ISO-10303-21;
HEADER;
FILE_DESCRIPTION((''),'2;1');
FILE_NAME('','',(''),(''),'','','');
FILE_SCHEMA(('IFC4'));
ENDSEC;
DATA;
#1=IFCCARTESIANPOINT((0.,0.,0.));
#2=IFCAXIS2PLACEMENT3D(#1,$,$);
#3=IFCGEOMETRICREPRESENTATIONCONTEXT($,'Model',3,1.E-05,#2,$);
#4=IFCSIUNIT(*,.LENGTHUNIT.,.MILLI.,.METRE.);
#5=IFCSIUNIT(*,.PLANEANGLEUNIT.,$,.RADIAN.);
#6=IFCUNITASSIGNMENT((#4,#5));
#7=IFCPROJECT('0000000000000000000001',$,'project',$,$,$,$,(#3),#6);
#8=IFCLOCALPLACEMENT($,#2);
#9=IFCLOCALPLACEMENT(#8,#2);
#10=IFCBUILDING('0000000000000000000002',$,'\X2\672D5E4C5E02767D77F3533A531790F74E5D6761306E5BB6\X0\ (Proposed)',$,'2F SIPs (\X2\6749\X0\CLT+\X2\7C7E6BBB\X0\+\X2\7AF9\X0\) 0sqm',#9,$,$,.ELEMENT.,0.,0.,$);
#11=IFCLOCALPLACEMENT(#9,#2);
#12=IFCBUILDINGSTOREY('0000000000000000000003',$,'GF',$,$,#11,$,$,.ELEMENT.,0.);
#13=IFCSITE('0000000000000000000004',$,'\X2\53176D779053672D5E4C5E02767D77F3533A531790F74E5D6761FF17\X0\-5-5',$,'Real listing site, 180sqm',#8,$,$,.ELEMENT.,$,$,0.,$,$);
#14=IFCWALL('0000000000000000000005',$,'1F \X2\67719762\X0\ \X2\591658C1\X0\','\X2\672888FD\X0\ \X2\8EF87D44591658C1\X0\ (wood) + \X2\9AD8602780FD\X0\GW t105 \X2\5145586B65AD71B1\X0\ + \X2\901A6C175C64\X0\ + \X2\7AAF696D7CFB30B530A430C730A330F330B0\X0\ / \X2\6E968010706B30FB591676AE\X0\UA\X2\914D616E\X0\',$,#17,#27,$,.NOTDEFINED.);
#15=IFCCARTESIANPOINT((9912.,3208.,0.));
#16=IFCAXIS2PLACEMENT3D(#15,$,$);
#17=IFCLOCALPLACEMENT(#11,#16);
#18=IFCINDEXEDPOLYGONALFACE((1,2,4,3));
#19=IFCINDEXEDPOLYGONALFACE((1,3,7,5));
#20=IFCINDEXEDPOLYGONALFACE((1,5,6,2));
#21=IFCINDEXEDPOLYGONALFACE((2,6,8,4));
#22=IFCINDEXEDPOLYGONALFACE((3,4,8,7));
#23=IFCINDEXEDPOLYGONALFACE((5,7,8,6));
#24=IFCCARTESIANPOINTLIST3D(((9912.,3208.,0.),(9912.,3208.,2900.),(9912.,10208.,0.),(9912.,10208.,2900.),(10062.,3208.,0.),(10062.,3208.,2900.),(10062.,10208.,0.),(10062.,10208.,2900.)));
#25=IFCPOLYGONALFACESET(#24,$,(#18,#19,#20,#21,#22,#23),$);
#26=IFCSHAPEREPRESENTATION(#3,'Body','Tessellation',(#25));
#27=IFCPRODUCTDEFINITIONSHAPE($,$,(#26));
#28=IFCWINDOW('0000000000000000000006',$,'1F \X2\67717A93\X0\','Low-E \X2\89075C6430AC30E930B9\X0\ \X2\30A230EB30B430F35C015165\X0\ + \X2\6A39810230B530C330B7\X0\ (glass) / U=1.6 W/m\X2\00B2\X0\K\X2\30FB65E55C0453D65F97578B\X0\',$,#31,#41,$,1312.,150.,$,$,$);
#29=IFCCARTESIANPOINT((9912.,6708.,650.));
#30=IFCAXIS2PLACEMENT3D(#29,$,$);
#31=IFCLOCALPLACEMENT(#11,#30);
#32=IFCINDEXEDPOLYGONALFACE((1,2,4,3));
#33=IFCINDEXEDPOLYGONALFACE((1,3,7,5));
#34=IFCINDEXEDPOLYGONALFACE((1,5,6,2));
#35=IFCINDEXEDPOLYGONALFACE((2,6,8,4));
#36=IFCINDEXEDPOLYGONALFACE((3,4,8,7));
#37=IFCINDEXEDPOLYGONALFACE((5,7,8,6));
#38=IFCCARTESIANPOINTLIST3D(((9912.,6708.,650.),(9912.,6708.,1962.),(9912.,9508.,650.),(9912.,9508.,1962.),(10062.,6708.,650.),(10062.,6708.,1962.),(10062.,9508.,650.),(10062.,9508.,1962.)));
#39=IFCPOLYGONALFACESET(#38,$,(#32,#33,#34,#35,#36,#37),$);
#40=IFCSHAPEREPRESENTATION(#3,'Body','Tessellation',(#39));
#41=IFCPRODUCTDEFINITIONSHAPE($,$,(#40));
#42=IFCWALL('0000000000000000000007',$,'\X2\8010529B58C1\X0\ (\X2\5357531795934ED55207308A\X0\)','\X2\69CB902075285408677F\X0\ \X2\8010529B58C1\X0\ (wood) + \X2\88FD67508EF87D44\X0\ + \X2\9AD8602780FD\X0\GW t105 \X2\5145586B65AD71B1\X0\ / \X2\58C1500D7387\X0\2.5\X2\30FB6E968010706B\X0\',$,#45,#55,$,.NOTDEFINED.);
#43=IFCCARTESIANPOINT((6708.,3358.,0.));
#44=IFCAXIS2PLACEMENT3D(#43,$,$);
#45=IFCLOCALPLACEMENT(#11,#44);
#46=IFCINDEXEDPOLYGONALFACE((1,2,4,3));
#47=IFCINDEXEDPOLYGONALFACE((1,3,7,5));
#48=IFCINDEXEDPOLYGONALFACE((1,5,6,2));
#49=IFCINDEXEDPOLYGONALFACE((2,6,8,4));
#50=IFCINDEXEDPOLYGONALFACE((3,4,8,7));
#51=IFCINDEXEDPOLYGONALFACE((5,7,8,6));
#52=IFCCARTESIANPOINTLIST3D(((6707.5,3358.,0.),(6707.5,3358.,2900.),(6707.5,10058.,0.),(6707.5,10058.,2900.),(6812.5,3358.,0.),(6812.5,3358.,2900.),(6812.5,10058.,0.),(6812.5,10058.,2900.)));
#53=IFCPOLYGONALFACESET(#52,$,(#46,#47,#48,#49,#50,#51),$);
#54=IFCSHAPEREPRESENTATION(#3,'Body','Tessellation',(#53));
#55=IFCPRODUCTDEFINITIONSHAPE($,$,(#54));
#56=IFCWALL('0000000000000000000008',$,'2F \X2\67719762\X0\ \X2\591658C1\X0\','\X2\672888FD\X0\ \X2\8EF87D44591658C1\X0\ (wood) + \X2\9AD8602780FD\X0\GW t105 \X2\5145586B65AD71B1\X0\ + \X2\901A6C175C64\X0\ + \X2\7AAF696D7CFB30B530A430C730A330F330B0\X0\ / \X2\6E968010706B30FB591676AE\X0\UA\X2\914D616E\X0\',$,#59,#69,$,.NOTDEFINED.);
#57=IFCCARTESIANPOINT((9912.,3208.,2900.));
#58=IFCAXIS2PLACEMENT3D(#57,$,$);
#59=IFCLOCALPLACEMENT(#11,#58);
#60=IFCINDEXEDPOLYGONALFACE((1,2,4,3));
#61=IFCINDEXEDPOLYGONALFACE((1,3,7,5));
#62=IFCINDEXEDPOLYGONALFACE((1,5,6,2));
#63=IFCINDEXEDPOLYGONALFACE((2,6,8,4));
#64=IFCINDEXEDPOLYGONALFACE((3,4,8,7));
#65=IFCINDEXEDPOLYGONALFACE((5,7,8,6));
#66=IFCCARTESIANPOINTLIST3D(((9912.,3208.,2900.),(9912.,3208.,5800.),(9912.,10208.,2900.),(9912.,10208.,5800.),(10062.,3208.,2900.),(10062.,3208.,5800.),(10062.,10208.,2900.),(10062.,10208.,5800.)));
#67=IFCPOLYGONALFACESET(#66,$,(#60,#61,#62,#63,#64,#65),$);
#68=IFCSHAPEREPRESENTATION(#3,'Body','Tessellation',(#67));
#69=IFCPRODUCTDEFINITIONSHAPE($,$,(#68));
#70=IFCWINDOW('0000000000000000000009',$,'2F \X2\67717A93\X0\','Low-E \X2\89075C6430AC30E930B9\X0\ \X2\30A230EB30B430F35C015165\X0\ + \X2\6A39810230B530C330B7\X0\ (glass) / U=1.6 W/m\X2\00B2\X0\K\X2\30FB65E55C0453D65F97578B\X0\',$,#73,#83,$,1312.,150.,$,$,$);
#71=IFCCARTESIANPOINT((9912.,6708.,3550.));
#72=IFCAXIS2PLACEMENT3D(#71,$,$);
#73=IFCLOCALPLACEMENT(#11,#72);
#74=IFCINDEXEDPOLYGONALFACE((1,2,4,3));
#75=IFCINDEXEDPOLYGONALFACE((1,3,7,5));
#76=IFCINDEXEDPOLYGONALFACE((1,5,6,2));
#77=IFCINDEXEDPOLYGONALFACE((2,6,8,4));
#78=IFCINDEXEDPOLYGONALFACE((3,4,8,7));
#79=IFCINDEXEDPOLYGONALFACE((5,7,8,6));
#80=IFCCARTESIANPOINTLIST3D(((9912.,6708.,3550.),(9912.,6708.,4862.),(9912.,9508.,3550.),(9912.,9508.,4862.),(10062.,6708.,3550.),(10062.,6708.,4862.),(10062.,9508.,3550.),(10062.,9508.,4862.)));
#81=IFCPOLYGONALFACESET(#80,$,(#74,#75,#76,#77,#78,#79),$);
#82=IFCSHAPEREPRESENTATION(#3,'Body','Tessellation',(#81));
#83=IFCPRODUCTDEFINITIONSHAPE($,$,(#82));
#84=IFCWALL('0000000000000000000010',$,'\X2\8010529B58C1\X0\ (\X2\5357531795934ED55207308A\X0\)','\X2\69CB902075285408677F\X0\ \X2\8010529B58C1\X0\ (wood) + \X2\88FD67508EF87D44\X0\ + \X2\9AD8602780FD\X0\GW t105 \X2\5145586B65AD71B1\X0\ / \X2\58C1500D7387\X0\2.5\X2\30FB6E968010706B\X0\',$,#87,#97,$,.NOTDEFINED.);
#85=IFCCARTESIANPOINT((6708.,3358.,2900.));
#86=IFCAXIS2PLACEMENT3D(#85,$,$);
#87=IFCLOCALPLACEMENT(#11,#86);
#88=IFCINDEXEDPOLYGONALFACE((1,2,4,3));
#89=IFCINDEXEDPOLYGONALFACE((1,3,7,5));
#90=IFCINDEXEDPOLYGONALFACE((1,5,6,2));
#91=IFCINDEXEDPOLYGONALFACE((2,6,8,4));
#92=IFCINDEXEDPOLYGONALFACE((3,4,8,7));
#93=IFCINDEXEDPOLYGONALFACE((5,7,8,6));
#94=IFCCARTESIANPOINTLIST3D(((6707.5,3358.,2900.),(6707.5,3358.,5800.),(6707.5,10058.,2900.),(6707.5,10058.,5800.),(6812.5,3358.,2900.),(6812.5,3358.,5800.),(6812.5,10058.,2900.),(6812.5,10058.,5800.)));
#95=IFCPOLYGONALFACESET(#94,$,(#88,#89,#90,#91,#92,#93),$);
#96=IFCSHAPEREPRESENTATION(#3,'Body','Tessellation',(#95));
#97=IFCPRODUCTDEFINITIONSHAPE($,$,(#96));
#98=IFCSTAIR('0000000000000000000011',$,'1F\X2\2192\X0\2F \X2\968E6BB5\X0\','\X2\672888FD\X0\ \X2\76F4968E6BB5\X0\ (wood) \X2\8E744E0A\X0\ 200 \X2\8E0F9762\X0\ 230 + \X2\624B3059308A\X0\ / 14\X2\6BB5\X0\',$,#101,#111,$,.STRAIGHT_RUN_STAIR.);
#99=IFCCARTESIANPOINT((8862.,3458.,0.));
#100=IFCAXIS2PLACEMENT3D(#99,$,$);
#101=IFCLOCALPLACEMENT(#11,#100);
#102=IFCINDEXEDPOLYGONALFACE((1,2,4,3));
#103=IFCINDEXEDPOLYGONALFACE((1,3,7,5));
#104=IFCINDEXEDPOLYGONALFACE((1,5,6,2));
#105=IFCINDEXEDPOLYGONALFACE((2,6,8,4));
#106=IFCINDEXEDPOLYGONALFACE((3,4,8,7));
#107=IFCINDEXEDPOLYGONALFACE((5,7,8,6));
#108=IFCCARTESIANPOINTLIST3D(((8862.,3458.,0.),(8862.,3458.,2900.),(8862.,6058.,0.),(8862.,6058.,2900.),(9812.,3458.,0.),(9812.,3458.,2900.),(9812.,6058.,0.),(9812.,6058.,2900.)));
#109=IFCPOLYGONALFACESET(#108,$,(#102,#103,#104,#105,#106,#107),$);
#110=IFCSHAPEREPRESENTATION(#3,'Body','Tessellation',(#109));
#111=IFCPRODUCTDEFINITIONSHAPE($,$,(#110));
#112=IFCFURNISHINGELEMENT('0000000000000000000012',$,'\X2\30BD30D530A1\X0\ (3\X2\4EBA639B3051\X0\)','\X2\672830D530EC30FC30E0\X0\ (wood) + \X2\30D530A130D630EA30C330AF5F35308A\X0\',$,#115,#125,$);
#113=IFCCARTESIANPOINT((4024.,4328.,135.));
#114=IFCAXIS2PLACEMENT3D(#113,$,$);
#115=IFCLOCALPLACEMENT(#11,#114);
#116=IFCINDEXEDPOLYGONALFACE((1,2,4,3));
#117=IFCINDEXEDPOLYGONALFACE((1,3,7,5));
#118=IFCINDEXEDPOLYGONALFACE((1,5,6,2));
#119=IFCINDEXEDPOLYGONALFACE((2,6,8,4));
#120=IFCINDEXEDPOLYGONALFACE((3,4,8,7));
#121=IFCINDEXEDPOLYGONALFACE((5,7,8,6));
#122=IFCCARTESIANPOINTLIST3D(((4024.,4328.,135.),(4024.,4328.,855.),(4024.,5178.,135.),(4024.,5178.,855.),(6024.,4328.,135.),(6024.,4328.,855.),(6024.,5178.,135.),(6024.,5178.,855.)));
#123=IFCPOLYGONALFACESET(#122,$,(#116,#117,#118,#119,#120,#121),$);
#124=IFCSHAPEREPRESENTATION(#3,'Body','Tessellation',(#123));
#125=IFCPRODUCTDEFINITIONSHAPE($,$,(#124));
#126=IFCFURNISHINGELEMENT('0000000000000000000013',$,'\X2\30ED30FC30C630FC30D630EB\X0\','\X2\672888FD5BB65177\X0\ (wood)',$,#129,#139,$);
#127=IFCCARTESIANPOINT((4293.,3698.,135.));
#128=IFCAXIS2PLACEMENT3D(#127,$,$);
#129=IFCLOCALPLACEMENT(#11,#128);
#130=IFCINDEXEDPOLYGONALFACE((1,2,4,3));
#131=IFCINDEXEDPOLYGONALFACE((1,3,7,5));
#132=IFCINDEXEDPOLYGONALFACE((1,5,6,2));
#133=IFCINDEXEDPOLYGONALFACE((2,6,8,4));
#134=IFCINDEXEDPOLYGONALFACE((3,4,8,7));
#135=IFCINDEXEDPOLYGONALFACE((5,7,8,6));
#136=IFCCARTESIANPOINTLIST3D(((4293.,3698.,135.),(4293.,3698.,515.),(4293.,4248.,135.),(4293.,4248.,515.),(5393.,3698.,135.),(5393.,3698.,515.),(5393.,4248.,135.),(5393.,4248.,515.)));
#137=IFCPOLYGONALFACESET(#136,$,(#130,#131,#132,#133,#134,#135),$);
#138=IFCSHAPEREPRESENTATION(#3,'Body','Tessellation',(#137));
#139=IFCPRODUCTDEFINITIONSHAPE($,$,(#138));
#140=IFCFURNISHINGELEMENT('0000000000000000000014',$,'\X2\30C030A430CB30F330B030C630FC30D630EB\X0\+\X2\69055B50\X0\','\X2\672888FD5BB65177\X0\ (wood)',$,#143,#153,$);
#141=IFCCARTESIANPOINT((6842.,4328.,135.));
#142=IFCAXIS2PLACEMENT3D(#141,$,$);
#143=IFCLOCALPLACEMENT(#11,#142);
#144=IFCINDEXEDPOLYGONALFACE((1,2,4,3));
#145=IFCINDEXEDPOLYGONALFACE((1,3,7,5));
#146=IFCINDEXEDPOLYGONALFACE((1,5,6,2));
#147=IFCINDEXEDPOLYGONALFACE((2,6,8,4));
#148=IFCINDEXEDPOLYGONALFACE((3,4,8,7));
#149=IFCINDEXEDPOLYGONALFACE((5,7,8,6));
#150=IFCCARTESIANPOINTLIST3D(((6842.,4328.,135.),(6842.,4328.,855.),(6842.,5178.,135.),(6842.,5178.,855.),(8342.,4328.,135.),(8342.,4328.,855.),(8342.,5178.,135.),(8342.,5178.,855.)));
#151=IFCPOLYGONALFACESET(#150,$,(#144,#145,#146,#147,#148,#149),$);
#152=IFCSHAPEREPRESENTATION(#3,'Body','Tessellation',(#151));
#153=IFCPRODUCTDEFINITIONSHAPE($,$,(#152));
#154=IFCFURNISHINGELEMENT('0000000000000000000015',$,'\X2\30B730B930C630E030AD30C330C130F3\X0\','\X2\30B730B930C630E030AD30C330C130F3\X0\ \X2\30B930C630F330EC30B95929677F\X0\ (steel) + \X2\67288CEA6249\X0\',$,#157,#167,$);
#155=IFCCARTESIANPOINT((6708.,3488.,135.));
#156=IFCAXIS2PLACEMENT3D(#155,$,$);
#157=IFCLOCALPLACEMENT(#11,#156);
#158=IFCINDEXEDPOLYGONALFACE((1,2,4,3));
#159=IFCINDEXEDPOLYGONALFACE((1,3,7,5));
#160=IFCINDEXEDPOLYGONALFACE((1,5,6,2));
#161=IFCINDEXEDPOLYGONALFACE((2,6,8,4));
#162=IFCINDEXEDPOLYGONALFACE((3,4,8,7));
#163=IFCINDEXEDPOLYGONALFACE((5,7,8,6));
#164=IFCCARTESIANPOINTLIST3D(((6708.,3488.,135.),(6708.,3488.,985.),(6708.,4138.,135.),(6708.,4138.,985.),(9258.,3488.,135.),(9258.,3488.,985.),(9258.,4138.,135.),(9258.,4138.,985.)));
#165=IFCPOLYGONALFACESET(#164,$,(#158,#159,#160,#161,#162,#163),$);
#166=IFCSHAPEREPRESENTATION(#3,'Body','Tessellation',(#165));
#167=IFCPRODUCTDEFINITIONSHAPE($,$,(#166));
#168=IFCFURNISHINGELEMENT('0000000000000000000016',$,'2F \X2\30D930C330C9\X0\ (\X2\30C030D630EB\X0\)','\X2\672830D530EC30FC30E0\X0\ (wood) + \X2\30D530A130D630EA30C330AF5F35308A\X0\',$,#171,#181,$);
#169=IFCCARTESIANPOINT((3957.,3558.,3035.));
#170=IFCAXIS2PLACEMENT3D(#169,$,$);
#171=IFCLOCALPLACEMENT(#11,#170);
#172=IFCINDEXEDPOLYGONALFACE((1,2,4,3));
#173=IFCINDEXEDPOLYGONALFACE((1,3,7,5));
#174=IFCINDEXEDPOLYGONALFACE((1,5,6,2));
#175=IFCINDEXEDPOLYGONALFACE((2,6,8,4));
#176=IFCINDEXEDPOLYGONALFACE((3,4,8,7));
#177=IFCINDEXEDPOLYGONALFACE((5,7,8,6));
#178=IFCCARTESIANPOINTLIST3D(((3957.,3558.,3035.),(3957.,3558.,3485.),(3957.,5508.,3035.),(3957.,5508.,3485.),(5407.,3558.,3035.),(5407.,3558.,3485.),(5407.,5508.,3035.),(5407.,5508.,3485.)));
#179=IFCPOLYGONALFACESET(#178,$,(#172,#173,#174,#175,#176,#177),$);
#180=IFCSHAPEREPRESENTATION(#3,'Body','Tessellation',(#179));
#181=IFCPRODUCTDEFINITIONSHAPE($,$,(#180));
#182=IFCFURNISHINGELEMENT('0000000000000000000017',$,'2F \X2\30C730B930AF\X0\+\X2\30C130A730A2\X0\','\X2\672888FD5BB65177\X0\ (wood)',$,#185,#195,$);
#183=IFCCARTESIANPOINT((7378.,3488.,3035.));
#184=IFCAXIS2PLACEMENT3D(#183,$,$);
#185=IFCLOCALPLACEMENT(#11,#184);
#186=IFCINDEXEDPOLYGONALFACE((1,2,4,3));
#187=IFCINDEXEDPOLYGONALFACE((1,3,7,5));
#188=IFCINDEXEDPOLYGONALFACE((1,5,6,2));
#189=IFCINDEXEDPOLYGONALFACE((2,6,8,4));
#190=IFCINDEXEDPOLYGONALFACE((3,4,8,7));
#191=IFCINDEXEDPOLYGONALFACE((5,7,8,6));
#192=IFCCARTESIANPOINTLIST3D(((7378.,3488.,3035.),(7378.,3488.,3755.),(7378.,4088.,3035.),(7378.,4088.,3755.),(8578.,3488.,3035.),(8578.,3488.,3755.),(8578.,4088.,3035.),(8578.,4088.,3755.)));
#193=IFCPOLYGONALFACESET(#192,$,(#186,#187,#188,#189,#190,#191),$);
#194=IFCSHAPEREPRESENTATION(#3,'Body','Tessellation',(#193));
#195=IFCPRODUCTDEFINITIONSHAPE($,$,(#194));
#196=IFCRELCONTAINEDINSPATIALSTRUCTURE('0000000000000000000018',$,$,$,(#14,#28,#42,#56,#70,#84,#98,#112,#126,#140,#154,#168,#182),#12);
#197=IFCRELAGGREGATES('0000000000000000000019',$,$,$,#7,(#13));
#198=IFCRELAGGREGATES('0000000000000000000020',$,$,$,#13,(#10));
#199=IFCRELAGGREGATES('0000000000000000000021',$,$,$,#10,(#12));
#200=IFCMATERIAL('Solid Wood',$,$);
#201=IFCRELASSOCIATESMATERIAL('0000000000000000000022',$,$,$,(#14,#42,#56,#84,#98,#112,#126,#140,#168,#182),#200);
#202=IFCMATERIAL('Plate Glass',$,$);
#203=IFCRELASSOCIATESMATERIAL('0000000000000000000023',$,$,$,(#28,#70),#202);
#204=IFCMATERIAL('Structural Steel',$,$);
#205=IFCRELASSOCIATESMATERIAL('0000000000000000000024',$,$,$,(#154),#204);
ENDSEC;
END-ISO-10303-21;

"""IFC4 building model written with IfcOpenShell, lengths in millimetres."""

from ifc_helpers import new_model, si_unit, frame, frame_2d, origin, place, context, project, spatial, rectangle, extrude, material, element, fill, save


model = new_model("IFC4")

# Units and contexts
model_context = context("Model", 3, precision=1e-05, world=origin())
ifc_project = project(units=[si_unit("LENGTHUNIT", "METRE", prefix="MILLI"), si_unit("PLANEANGLEUNIT", "RADIAN")], contexts=[model_context])

# Site, building, storey
site_placement = place(None, origin())
site = spatial("IfcSite", under=ifc_project, at=site_placement, Name="北海道札幌市白石区北郷九条７-5-5", ObjectType="Real listing site, 180sqm", CompositionType="ELEMENT", RefElevation=0.0)
building_placement = place(site_placement, origin())
building = spatial("IfcBuilding", under=site, at=building_placement, Name="札幌市白石区北郷九条の家 (Proposed)", ObjectType="2F SIPs (杉CLT+籾殻+竹) 0sqm", CompositionType="ELEMENT", ElevationOfRefHeight=0.0, ElevationOfTerrain=0.0)
storey_placement = place(building_placement, origin())
storey = spatial("IfcBuildingStorey", under=building, at=storey_placement, Name="GF", CompositionType="ELEMENT", Elevation=0.0)

# Wall, opening, window
ifc_material_1 = material(Name="Solid Wood")
wall_1_placement = place(storey_placement, frame((9912.0, 3208.0, 0.0)))
wall_1 = element("IfcWall", 1, at=wall_1_placement, inside=storey, material=ifc_material_1, Name="1F 東面 外壁", Description="木製 軸組外壁 (wood) + 高性能GW t105 充填断熱 + 通気層 + 窯業系サイディング / 準耐火・外皮UA配慮", PredefinedType="NOTDEFINED", context=model_context, shape_type="SweptSolid", body=[
    extrude(rectangle(XDim=150.0, YDim=7000.0, at=frame_2d((75.0, 3500.0))), frame((9912.0, 3208.0, 0.0)), (0.0, 0.0, 1.0), 2900.0),
])
opening_1_placement = place(storey_placement, frame((9912.0, 6708.0, 650.0)))
opening_1 = element("IfcOpeningElement", 2, at=opening_1_placement, cuts=wall_1, PredefinedType="NOTDEFINED", context=model_context, shape_type="SweptSolid", body=[
    extrude(rectangle(XDim=150.0, YDim=2800.0, at=frame_2d((75.0, 1400.0))), frame((9912.0, 6708.0, 650.0)), (0.0, 0.0, 1.0), 1312.0),
])
ifc_material_2 = material(Name="Plate Glass")
window_1_placement = place(storey_placement, frame((9912.0, 6708.0, 650.0)))
window_1 = element("IfcWindow", 3, at=window_1_placement, inside=storey, material=ifc_material_2, Name="1F 東窓", Description="Low-E 複層ガラス アルゴン封入 + 樹脂サッシ (glass) / U=1.6 W/m²K・日射取得型", OverallHeight=1312.0, OverallWidth=150.0, context=model_context, shape_type="SweptSolid", body=[
    extrude(rectangle(XDim=150.0, YDim=2800.0, at=frame_2d((75.0, 1400.0))), frame((9912.0, 6708.0, 650.0)), (0.0, 0.0, 1.0), 1312.0),
])
fill(opening_1, window_1)

# Wall
wall_2_placement = place(storey_placement, frame((6708.0, 3358.0, 0.0)))
element("IfcWall", 4, at=wall_2_placement, inside=storey, material=ifc_material_1, Name="耐力壁 (南北間仕切り)", Description="構造用合板 耐力壁 (wood) + 製材軸組 + 高性能GW t105 充填断熱 / 壁倍率2.5・準耐火", PredefinedType="NOTDEFINED", context=model_context, shape_type="SweptSolid", body=[
    extrude(rectangle(XDim=105.0, YDim=6700.0, at=frame_2d((52.0, 3350.0))), frame((6708.0, 3358.0, 0.0)), (0.0, 0.0, 1.0), 2900.0),
])

# Wall, opening, window
wall_3_placement = place(storey_placement, frame((9912.0, 3208.0, 2900.0)))
wall_3 = element("IfcWall", 5, at=wall_3_placement, inside=storey, material=ifc_material_1, Name="2F 東面 外壁", Description="木製 軸組外壁 (wood) + 高性能GW t105 充填断熱 + 通気層 + 窯業系サイディング / 準耐火・外皮UA配慮", PredefinedType="NOTDEFINED", context=model_context, shape_type="SweptSolid", body=[
    extrude(rectangle(XDim=150.0, YDim=7000.0, at=frame_2d((75.0, 3500.0))), frame((9912.0, 3208.0, 2900.0)), (0.0, 0.0, 1.0), 2900.0),
])
opening_2_placement = place(storey_placement, frame((9912.0, 6708.0, 3550.0)))
opening_2 = element("IfcOpeningElement", 6, at=opening_2_placement, cuts=wall_3, PredefinedType="NOTDEFINED", context=model_context, shape_type="SweptSolid", body=[
    extrude(rectangle(XDim=150.0, YDim=2800.0, at=frame_2d((75.0, 1400.0))), frame((9912.0, 6708.0, 3550.0)), (0.0, 0.0, 1.0), 1312.0),
])
window_2_placement = place(storey_placement, frame((9912.0, 6708.0, 3550.0)))
window_2 = element("IfcWindow", 7, at=window_2_placement, inside=storey, material=ifc_material_2, Name="2F 東窓", Description="Low-E 複層ガラス アルゴン封入 + 樹脂サッシ (glass) / U=1.6 W/m²K・日射取得型", OverallHeight=1312.0, OverallWidth=150.0, context=model_context, shape_type="SweptSolid", body=[
    extrude(rectangle(XDim=150.0, YDim=2800.0, at=frame_2d((75.0, 1400.0))), frame((9912.0, 6708.0, 3550.0)), (0.0, 0.0, 1.0), 1312.0),
])
fill(opening_2, window_2)

# Wall
wall_4_placement = place(storey_placement, frame((6708.0, 3358.0, 2900.0)))
element("IfcWall", 8, at=wall_4_placement, inside=storey, material=ifc_material_1, Name="耐力壁 (南北間仕切り)", Description="構造用合板 耐力壁 (wood) + 製材軸組 + 高性能GW t105 充填断熱 / 壁倍率2.5・準耐火", PredefinedType="NOTDEFINED", context=model_context, shape_type="SweptSolid", body=[
    extrude(rectangle(XDim=105.0, YDim=6700.0, at=frame_2d((52.0, 3350.0))), frame((6708.0, 3358.0, 2900.0)), (0.0, 0.0, 1.0), 2900.0),
])

# Stair
stair_placement = place(storey_placement, frame((8862.0, 3458.0, 0.0)))
element("IfcStair", 9, at=stair_placement, inside=storey, material=ifc_material_1, Name="1F→2F 階段", Description="木製 直階段 (wood) 蹴上 200 踏面 230 + 手すり / 14段", PredefinedType="STRAIGHT_RUN_STAIR", context=model_context, shape_type="SweptSolid", body=[
    extrude(rectangle(XDim=950.0, YDim=2600.0, at=frame_2d((475.0, 1300.0))), frame((8862.0, 3458.0, 0.0)), (0.0, 0.0, 1.0), 2900.0),
])

# Furnishing elements
furnishing_1_placement = place(storey_placement, frame((4024.0, 4328.0, 135.0)))
element("IfcFurnishingElement", 10, at=furnishing_1_placement, inside=storey, material=ifc_material_1, Name="ソファ (3人掛け)", Description="木フレーム (wood) + ファブリック張り", context=model_context, shape_type="SweptSolid", body=[
    extrude(rectangle(XDim=2000.0, YDim=850.0, at=frame_2d((1000.0, 425.0))), frame((4024.0, 4328.0, 135.0)), (0.0, 0.0, 1.0), 720.0),
])
furnishing_2_placement = place(storey_placement, frame((4293.0, 3698.0, 135.0)))
element("IfcFurnishingElement", 11, at=furnishing_2_placement, inside=storey, material=ifc_material_1, Name="ローテーブル", Description="木製家具 (wood)", context=model_context, shape_type="SweptSolid", body=[
    extrude(rectangle(XDim=1100.0, YDim=550.0, at=frame_2d((550.0, 275.0))), frame((4293.0, 3698.0, 135.0)), (0.0, 0.0, 1.0), 380.0),
])
furnishing_3_placement = place(storey_placement, frame((6842.0, 4328.0, 135.0)))
element("IfcFurnishingElement", 12, at=furnishing_3_placement, inside=storey, material=ifc_material_1, Name="ダイニングテーブル+椅子", Description="木製家具 (wood)", context=model_context, shape_type="SweptSolid", body=[
    extrude(rectangle(XDim=1500.0, YDim=850.0, at=frame_2d((750.0, 425.0))), frame((6842.0, 4328.0, 135.0)), (0.0, 0.0, 1.0), 720.0),
])
ifc_material_3 = material(Name="Structural Steel")
furnishing_4_placement = place(storey_placement, frame((6708.0, 3488.0, 135.0)))
element("IfcFurnishingElement", 13, at=furnishing_4_placement, inside=storey, material=ifc_material_3, Name="システムキッチン", Description="システムキッチン ステンレス天板 (steel) + 木質扉", context=model_context, shape_type="SweptSolid", body=[
    extrude(rectangle(XDim=2550.0, YDim=650.0, at=frame_2d((1275.0, 325.0))), frame((6708.0, 3488.0, 135.0)), (0.0, 0.0, 1.0), 850.0),
])
furnishing_5_placement = place(storey_placement, frame((3957.0, 3558.0, 3035.0)))
element("IfcFurnishingElement", 14, at=furnishing_5_placement, inside=storey, material=ifc_material_1, Name="2F ベッド (ダブル)", Description="木フレーム (wood) + ファブリック張り", context=model_context, shape_type="SweptSolid", body=[
    extrude(rectangle(XDim=1450.0, YDim=1950.0, at=frame_2d((725.0, 975.0))), frame((3957.0, 3558.0, 3035.0)), (0.0, 0.0, 1.0), 450.0),
])
furnishing_6_placement = place(storey_placement, frame((7378.0, 3488.0, 3035.0)))
element("IfcFurnishingElement", 15, at=furnishing_6_placement, inside=storey, material=ifc_material_1, Name="2F デスク+チェア", Description="木製家具 (wood)", context=model_context, shape_type="SweptSolid", body=[
    extrude(rectangle(XDim=1200.0, YDim=600.0, at=frame_2d((600.0, 300.0))), frame((7378.0, 3488.0, 3035.0)), (0.0, 0.0, 1.0), 720.0),
])

save(model, "model.ifc")
